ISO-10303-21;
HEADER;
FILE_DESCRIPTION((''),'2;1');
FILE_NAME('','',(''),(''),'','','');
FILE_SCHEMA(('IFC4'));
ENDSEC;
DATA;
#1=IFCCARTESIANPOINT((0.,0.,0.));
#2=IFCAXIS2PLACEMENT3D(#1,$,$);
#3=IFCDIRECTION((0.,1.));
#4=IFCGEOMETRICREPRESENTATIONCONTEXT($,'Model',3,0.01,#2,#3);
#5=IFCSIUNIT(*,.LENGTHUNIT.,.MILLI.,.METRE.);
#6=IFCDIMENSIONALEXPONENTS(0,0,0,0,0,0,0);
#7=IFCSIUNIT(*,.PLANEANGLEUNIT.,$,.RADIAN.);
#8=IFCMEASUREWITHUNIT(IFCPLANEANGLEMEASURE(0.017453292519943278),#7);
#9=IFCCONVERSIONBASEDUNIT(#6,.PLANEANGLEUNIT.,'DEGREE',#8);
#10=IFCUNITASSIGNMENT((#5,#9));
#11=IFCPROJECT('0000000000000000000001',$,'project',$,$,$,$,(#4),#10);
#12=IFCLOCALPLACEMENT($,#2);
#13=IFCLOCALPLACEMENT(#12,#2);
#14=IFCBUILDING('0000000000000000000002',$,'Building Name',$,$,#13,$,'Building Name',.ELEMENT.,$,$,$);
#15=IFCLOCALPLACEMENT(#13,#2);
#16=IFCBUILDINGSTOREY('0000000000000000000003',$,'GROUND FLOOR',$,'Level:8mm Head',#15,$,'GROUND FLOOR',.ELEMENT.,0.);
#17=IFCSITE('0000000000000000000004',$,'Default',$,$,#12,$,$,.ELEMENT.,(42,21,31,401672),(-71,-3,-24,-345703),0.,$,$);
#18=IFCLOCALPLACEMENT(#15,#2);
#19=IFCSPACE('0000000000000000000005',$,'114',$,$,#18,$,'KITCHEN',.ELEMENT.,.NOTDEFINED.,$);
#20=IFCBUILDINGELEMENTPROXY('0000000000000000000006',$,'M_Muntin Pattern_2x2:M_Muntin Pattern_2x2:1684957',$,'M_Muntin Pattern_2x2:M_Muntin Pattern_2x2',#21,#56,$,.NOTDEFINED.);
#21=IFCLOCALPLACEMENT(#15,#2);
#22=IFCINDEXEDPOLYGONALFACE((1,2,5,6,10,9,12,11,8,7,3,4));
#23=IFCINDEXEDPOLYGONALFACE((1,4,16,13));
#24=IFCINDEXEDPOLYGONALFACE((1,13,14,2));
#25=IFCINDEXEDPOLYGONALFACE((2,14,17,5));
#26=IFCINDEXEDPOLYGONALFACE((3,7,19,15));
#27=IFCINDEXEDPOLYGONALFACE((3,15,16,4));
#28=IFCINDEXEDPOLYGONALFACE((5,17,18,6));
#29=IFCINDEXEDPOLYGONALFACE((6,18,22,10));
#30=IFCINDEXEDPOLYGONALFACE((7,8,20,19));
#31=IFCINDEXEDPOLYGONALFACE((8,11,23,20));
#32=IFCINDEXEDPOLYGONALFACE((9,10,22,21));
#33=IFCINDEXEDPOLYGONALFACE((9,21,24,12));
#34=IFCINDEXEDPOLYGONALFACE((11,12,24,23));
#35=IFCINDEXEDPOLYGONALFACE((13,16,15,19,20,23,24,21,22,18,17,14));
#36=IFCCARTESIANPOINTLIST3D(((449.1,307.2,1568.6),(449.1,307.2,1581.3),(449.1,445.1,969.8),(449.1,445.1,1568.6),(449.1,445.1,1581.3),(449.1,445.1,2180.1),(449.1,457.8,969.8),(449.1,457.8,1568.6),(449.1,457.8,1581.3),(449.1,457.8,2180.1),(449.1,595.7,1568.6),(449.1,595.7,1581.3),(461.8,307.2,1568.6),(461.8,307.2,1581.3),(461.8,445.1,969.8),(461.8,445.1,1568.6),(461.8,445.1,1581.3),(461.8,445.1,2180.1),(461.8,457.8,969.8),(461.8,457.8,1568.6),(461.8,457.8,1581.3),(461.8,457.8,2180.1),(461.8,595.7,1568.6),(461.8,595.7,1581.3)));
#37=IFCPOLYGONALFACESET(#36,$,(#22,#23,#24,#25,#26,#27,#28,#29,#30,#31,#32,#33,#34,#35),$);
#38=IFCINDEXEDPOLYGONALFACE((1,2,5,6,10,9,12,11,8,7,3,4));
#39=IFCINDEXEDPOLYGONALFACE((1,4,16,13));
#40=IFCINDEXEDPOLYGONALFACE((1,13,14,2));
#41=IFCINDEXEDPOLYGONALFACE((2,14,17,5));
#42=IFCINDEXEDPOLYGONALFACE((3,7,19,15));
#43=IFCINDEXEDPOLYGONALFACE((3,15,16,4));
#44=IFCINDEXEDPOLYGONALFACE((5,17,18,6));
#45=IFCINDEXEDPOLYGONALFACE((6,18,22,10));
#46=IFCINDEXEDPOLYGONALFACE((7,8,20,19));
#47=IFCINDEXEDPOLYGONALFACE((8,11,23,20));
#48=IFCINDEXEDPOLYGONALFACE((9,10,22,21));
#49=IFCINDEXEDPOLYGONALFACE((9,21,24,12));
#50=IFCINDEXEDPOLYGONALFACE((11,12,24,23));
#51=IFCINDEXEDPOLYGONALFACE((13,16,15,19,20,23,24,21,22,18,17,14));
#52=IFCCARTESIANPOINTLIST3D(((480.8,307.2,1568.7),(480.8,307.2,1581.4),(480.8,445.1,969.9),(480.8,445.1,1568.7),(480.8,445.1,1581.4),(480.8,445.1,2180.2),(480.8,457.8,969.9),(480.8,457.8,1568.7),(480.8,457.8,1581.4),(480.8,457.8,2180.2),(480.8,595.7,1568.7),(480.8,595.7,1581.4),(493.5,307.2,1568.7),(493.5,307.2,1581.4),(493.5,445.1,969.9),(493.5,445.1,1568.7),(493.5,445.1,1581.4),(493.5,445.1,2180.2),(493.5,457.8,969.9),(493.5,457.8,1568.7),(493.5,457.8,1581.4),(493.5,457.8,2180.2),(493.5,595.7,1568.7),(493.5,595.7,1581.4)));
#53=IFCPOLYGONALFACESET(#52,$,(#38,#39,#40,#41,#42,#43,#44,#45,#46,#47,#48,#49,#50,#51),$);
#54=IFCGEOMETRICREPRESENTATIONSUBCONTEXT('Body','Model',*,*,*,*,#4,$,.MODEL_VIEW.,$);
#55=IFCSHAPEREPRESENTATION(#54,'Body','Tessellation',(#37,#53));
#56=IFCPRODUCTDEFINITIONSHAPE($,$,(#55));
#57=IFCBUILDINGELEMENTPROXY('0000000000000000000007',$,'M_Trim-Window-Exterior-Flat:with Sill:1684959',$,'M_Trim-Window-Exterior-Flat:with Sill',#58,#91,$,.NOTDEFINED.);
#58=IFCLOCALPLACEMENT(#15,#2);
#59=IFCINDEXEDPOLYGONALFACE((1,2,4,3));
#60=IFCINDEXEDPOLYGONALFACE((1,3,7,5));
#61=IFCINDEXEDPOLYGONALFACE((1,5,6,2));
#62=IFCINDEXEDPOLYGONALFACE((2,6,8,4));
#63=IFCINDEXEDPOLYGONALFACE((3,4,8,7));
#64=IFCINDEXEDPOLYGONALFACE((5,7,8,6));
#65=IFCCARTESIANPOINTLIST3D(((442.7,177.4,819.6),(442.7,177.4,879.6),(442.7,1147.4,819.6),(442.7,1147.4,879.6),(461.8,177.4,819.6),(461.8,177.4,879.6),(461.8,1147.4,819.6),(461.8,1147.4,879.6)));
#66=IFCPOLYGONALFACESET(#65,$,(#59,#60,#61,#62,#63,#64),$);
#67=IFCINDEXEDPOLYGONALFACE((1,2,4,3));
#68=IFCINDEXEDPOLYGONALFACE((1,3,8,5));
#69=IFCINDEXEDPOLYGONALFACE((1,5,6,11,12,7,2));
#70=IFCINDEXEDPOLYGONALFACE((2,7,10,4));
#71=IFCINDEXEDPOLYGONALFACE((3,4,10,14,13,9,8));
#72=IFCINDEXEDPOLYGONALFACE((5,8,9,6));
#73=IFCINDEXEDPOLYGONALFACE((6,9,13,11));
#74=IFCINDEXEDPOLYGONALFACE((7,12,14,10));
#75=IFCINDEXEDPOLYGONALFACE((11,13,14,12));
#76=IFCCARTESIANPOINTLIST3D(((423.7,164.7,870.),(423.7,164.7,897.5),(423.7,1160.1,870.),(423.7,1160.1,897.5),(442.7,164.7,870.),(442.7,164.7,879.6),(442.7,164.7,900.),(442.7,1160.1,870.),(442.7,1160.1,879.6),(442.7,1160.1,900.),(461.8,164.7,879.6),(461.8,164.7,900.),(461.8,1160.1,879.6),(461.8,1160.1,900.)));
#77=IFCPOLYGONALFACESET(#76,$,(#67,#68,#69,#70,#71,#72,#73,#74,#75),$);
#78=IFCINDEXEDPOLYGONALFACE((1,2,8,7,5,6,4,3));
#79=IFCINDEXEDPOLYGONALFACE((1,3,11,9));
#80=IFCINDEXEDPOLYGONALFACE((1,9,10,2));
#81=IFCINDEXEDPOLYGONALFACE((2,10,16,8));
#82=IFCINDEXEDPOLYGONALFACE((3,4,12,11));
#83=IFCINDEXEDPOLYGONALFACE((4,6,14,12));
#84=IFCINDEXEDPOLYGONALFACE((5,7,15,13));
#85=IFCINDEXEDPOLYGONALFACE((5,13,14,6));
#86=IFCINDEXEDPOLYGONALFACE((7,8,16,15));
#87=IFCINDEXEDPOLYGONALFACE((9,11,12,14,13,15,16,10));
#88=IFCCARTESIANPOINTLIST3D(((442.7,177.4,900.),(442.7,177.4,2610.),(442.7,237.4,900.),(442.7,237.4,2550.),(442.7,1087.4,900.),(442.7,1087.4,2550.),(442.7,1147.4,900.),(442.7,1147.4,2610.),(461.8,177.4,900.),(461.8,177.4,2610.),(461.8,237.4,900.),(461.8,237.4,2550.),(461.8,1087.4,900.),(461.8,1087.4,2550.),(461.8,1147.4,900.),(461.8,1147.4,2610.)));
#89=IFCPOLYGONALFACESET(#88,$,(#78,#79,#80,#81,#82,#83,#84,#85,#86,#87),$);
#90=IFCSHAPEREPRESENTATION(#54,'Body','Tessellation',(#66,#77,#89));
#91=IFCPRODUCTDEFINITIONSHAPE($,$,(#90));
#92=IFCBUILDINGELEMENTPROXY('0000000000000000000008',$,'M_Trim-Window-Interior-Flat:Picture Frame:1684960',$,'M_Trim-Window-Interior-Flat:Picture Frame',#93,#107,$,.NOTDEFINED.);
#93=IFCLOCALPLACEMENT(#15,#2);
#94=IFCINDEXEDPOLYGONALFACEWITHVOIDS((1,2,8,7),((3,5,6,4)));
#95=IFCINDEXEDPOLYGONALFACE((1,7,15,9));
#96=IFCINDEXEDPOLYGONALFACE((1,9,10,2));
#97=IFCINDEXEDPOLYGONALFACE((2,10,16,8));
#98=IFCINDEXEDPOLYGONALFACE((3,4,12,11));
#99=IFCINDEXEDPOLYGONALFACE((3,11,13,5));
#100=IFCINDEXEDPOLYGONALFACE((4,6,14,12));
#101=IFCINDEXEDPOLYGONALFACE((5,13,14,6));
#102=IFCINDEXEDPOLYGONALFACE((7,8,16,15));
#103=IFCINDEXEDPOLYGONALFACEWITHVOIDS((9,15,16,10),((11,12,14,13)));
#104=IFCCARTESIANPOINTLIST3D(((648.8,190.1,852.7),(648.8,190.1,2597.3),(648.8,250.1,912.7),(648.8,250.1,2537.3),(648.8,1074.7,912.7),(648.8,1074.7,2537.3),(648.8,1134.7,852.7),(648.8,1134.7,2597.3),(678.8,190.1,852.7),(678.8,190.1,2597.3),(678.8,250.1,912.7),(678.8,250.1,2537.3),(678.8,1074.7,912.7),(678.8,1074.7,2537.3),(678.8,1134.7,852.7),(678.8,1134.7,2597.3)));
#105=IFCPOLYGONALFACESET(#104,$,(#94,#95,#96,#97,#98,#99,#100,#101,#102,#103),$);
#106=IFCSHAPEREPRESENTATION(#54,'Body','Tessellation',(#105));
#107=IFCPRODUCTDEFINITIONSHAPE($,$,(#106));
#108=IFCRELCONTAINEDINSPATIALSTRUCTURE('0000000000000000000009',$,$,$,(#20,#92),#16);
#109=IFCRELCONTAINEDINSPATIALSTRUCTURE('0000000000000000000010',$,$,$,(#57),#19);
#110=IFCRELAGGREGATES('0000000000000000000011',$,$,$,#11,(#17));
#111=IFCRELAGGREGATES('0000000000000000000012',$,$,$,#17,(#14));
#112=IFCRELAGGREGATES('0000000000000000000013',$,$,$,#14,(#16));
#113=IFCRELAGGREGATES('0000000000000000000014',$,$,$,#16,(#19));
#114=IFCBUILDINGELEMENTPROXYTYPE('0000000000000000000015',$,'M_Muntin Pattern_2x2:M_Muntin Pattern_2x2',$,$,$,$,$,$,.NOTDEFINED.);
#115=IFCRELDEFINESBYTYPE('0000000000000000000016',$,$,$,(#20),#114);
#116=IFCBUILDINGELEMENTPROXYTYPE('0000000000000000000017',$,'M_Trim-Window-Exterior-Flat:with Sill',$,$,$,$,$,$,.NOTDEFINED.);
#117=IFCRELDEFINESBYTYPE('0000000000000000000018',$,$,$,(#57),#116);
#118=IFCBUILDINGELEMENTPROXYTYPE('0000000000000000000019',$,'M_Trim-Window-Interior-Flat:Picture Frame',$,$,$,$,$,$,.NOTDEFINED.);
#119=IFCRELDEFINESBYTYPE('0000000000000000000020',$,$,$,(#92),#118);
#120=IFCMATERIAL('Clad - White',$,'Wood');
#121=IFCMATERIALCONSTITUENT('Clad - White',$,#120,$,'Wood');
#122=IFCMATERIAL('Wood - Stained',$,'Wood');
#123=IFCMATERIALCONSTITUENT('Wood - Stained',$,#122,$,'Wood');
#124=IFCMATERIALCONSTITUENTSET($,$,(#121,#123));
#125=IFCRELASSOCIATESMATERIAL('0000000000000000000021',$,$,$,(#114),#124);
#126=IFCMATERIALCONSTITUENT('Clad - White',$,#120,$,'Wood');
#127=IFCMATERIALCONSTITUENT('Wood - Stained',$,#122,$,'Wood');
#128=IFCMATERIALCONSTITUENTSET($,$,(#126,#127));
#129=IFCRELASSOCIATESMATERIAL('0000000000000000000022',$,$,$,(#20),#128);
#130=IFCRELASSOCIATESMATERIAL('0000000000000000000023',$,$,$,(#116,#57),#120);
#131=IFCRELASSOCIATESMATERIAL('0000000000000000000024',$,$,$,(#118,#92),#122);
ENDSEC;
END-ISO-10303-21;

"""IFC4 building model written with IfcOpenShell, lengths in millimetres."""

from ifc_helpers import new_model, entity, si_unit, converted_unit, direction, frame, origin, place, context, subcontext, project, spatial, indexed_curve, outline, extrude, source, transform, mapped, material, constituent, constituent_set, type_object, type_shapes, element, save


model = new_model("IFC4")

# Units and contexts
model_context = context("Model", 3, precision=0.01, world=origin(), true_north=direction((0.0, 1.0)))
body_context = subcontext(model_context, "Body", "Model", "MODEL_VIEW")
ifc_project = project(units=[si_unit("LENGTHUNIT", "METRE", prefix="MILLI"), converted_unit("PLANEANGLEUNIT", "DEGREE", entity("IfcPlaneAngleMeasure", 0.017453292519943278), si_unit("PLANEANGLEUNIT", "RADIAN"), dimensions=[0, 0, 0, 0, 0, 0, 0])], contexts=[model_context])

# Site, building, storey
site_placement = place(None, origin())
site = spatial("IfcSite", under=ifc_project, at=site_placement, Name="Default", CompositionType="ELEMENT", RefLatitude=(42, 21, 31, 401672), RefLongitude=(-71, -3, -24, -345703), RefElevation=0.0)
building_placement = place(site_placement, origin())
building = spatial("IfcBuilding", under=site, at=building_placement, Name="Building Name", LongName="Building Name", CompositionType="ELEMENT")
storey_placement = place(building_placement, origin())
storey = spatial("IfcBuildingStorey", under=building, at=storey_placement, Name="GROUND FLOOR", ObjectType="Level:8mm Head", LongName="GROUND FLOOR", CompositionType="ELEMENT", Elevation=0.0)

# Building element proxy
ifc_material_1 = material(Name="Clad - White", Category="Wood")
ifc_constituent_1 = constituent(ifc_material_1, Name="Clad - White", Category="Wood")
ifc_material_2 = material(Name="Wood - Stained", Category="Wood")
ifc_constituent_2 = constituent(ifc_material_2, Name="Wood - Stained", Category="Wood")
ifc_constituent_set_1 = constituent_set(constituents=[ifc_constituent_1, ifc_constituent_2])
ifc_constituent_3 = constituent(ifc_material_1, Name="Clad - White", Category="Wood")
ifc_constituent_4 = constituent(ifc_material_2, Name="Wood - Stained", Category="Wood")
ifc_constituent_set_2 = constituent_set(constituents=[ifc_constituent_3, ifc_constituent_4])
building_element_proxy_type_1 = type_object("IfcBuildingElementProxyType", Name="M_Muntin Pattern_2x2:M_Muntin Pattern_2x2", PredefinedType="NOTDEFINED", material=ifc_constituent_set_2)
shared_shape_1 = source(origin(), body_context, "Body", "SweptSolid", [
    extrude(outline(indexed_curve([(6.4, -6.4), (605.1, -6.4), (605.1, 6.3), (6.4, 6.3), (6.4, 144.2), (-6.3, 144.2), (-6.3, 6.3), (-605.2, 6.3), (-605.2, -6.4), (-6.3, -6.4), (-6.3, -144.2), (6.4, -144.2), (6.4, -6.4)], self_intersect=False)), frame((0.0, 9.5, 605.1), z_axis=(0.0, 1.0, 0.0), x_axis=(0.0, 0.0, 1.0)), (0.0, 0.0, 1.0), 12.7),
    extrude(outline(indexed_curve([(6.4, -6.4), (605.2, -6.4), (605.2, 6.3), (6.4, 6.3), (6.4, 144.2), (-6.3, 144.2), (-6.3, 6.3), (-605.2, 6.3), (-605.2, -6.4), (-6.3, -6.4), (-6.3, -144.2), (6.4, -144.2), (6.4, -6.4)], self_intersect=False)), frame((0.0, -22.2, 605.2), z_axis=(0.0, 1.0, 0.0), x_axis=(0.0, 0.0, 1.0)), (0.0, 0.0, 1.0), 12.7),
])
type_shapes(building_element_proxy_type_1, [shared_shape_1])
proxy_1_placement = place(storey_placement, frame((471.3, 451.5, 969.9), z_axis=(0.0, 0.0, 1.0), x_axis=(0.0, 1.0, 0.0)))
element("IfcBuildingElementProxy", 1, at=proxy_1_placement, inside=storey, type_object=building_element_proxy_type_1, material=ifc_constituent_set_1, Name="M_Muntin Pattern_2x2:M_Muntin Pattern_2x2:1684957", ObjectType="M_Muntin Pattern_2x2:M_Muntin Pattern_2x2", PredefinedType="NOTDEFINED", context=body_context, shape_type="MappedRepresentation", body=[
    mapped(shared_shape_1, transform((0.0, 0.0, 0.0), scale=1.0)),
])

# Shared definitions
space_placement = place(storey_placement, origin())
space = spatial("IfcSpace", under=storey, at=space_placement, Name="114", LongName="KITCHEN", CompositionType="ELEMENT", PredefinedType="NOTDEFINED")

# Building element proxies
building_element_proxy_type_2 = type_object("IfcBuildingElementProxyType", Name="M_Trim-Window-Exterior-Flat:with Sill", PredefinedType="NOTDEFINED", material=ifc_material_1)
shared_shape_2 = source(origin(), body_context, "Body", "SweptSolid", [
    extrude(outline(indexed_curve([(-485.0, -30.0), (485.0, -30.0), (485.0, 30.0), (-485.0, 30.0), (-485.0, -30.0)], self_intersect=False)), frame((0.0, -1700.4, 0.0), z_axis=(0.0, 0.0, 1.0), x_axis=(-1.0, 0.0, 0.0)), (0.0, 0.0, 1.0), 19.0),
    extrude(outline(indexed_curve([(-19.0, -15.2), (0.0, -15.2), (0.0, -5.7), (19.0, -5.7), (19.0, 14.8), (0.0, 14.8), (-19.0, 12.3), (-19.0, -15.2)], self_intersect=False)), frame((-497.7, -1664.8, 19.0), z_axis=(1.0, 0.0, 0.0), x_axis=(0.0, 0.0, -1.0)), (0.0, 0.0, 1.0), 995.4),
    extrude(outline(indexed_curve([(-870.0, -485.0), (840.0, -485.0), (840.0, -425.0), (-810.0, -425.0), (-810.0, 425.0), (840.0, 425.0), (840.0, 485.0), (-870.0, 485.0), (-870.0, -485.0)], self_intersect=False)), frame((0.0, -810.0, 0.0), z_axis=(0.0, 0.0, 1.0), x_axis=(0.0, -1.0, 0.0)), (0.0, 0.0, 1.0), 19.0),
])
type_shapes(building_element_proxy_type_2, [shared_shape_2])
proxy_2_placement = place(space_placement, frame((461.8, 662.4, 2550.0), z_axis=(-1.0, 0.0, 0.0), x_axis=(0.0, -1.0, 0.0)))
element("IfcBuildingElementProxy", 2, at=proxy_2_placement, inside=space, type_object=building_element_proxy_type_2, material=ifc_material_1, Name="M_Trim-Window-Exterior-Flat:with Sill:1684959", ObjectType="M_Trim-Window-Exterior-Flat:with Sill", PredefinedType="NOTDEFINED", context=body_context, shape_type="MappedRepresentation", body=[
    mapped(shared_shape_2, transform((0.0, 0.0, 0.0), scale=1.0)),
])
building_element_proxy_type_3 = type_object("IfcBuildingElementProxyType", Name="M_Trim-Window-Interior-Flat:Picture Frame", PredefinedType="NOTDEFINED", material=ifc_material_2)
shared_shape_3 = source(origin(), body_context, "Body", "SweptSolid", [
    extrude(outline(indexed_curve([(-472.3, -872.3), (472.3, -872.3), (472.3, 872.3), (-472.3, 872.3), (-472.3, -872.3)], self_intersect=False), holes=[indexed_curve([(-412.3, -812.3), (-412.3, 812.3), (412.3, 812.3), (412.3, -812.3), (-412.3, -812.3)], self_intersect=False)]), frame((0.0, -825.0, 0.0), z_axis=(0.0, 0.0, 1.0), x_axis=(-1.0, 0.0, 0.0)), (0.0, 0.0, 1.0), 30.0),
])
type_shapes(building_element_proxy_type_3, [shared_shape_3])
proxy_3_placement = place(storey_placement, frame((648.8, 662.4, 2550.0), z_axis=(1.0, 0.0, 0.0), x_axis=(0.0, 1.0, 0.0)))
element("IfcBuildingElementProxy", 3, at=proxy_3_placement, inside=storey, type_object=building_element_proxy_type_3, material=ifc_material_2, Name="M_Trim-Window-Interior-Flat:Picture Frame:1684960", ObjectType="M_Trim-Window-Interior-Flat:Picture Frame", PredefinedType="NOTDEFINED", context=body_context, shape_type="MappedRepresentation", body=[
    mapped(shared_shape_3, transform((0.0, 0.0, 0.0), scale=1.0)),
])

save(model, "model.ifc")
